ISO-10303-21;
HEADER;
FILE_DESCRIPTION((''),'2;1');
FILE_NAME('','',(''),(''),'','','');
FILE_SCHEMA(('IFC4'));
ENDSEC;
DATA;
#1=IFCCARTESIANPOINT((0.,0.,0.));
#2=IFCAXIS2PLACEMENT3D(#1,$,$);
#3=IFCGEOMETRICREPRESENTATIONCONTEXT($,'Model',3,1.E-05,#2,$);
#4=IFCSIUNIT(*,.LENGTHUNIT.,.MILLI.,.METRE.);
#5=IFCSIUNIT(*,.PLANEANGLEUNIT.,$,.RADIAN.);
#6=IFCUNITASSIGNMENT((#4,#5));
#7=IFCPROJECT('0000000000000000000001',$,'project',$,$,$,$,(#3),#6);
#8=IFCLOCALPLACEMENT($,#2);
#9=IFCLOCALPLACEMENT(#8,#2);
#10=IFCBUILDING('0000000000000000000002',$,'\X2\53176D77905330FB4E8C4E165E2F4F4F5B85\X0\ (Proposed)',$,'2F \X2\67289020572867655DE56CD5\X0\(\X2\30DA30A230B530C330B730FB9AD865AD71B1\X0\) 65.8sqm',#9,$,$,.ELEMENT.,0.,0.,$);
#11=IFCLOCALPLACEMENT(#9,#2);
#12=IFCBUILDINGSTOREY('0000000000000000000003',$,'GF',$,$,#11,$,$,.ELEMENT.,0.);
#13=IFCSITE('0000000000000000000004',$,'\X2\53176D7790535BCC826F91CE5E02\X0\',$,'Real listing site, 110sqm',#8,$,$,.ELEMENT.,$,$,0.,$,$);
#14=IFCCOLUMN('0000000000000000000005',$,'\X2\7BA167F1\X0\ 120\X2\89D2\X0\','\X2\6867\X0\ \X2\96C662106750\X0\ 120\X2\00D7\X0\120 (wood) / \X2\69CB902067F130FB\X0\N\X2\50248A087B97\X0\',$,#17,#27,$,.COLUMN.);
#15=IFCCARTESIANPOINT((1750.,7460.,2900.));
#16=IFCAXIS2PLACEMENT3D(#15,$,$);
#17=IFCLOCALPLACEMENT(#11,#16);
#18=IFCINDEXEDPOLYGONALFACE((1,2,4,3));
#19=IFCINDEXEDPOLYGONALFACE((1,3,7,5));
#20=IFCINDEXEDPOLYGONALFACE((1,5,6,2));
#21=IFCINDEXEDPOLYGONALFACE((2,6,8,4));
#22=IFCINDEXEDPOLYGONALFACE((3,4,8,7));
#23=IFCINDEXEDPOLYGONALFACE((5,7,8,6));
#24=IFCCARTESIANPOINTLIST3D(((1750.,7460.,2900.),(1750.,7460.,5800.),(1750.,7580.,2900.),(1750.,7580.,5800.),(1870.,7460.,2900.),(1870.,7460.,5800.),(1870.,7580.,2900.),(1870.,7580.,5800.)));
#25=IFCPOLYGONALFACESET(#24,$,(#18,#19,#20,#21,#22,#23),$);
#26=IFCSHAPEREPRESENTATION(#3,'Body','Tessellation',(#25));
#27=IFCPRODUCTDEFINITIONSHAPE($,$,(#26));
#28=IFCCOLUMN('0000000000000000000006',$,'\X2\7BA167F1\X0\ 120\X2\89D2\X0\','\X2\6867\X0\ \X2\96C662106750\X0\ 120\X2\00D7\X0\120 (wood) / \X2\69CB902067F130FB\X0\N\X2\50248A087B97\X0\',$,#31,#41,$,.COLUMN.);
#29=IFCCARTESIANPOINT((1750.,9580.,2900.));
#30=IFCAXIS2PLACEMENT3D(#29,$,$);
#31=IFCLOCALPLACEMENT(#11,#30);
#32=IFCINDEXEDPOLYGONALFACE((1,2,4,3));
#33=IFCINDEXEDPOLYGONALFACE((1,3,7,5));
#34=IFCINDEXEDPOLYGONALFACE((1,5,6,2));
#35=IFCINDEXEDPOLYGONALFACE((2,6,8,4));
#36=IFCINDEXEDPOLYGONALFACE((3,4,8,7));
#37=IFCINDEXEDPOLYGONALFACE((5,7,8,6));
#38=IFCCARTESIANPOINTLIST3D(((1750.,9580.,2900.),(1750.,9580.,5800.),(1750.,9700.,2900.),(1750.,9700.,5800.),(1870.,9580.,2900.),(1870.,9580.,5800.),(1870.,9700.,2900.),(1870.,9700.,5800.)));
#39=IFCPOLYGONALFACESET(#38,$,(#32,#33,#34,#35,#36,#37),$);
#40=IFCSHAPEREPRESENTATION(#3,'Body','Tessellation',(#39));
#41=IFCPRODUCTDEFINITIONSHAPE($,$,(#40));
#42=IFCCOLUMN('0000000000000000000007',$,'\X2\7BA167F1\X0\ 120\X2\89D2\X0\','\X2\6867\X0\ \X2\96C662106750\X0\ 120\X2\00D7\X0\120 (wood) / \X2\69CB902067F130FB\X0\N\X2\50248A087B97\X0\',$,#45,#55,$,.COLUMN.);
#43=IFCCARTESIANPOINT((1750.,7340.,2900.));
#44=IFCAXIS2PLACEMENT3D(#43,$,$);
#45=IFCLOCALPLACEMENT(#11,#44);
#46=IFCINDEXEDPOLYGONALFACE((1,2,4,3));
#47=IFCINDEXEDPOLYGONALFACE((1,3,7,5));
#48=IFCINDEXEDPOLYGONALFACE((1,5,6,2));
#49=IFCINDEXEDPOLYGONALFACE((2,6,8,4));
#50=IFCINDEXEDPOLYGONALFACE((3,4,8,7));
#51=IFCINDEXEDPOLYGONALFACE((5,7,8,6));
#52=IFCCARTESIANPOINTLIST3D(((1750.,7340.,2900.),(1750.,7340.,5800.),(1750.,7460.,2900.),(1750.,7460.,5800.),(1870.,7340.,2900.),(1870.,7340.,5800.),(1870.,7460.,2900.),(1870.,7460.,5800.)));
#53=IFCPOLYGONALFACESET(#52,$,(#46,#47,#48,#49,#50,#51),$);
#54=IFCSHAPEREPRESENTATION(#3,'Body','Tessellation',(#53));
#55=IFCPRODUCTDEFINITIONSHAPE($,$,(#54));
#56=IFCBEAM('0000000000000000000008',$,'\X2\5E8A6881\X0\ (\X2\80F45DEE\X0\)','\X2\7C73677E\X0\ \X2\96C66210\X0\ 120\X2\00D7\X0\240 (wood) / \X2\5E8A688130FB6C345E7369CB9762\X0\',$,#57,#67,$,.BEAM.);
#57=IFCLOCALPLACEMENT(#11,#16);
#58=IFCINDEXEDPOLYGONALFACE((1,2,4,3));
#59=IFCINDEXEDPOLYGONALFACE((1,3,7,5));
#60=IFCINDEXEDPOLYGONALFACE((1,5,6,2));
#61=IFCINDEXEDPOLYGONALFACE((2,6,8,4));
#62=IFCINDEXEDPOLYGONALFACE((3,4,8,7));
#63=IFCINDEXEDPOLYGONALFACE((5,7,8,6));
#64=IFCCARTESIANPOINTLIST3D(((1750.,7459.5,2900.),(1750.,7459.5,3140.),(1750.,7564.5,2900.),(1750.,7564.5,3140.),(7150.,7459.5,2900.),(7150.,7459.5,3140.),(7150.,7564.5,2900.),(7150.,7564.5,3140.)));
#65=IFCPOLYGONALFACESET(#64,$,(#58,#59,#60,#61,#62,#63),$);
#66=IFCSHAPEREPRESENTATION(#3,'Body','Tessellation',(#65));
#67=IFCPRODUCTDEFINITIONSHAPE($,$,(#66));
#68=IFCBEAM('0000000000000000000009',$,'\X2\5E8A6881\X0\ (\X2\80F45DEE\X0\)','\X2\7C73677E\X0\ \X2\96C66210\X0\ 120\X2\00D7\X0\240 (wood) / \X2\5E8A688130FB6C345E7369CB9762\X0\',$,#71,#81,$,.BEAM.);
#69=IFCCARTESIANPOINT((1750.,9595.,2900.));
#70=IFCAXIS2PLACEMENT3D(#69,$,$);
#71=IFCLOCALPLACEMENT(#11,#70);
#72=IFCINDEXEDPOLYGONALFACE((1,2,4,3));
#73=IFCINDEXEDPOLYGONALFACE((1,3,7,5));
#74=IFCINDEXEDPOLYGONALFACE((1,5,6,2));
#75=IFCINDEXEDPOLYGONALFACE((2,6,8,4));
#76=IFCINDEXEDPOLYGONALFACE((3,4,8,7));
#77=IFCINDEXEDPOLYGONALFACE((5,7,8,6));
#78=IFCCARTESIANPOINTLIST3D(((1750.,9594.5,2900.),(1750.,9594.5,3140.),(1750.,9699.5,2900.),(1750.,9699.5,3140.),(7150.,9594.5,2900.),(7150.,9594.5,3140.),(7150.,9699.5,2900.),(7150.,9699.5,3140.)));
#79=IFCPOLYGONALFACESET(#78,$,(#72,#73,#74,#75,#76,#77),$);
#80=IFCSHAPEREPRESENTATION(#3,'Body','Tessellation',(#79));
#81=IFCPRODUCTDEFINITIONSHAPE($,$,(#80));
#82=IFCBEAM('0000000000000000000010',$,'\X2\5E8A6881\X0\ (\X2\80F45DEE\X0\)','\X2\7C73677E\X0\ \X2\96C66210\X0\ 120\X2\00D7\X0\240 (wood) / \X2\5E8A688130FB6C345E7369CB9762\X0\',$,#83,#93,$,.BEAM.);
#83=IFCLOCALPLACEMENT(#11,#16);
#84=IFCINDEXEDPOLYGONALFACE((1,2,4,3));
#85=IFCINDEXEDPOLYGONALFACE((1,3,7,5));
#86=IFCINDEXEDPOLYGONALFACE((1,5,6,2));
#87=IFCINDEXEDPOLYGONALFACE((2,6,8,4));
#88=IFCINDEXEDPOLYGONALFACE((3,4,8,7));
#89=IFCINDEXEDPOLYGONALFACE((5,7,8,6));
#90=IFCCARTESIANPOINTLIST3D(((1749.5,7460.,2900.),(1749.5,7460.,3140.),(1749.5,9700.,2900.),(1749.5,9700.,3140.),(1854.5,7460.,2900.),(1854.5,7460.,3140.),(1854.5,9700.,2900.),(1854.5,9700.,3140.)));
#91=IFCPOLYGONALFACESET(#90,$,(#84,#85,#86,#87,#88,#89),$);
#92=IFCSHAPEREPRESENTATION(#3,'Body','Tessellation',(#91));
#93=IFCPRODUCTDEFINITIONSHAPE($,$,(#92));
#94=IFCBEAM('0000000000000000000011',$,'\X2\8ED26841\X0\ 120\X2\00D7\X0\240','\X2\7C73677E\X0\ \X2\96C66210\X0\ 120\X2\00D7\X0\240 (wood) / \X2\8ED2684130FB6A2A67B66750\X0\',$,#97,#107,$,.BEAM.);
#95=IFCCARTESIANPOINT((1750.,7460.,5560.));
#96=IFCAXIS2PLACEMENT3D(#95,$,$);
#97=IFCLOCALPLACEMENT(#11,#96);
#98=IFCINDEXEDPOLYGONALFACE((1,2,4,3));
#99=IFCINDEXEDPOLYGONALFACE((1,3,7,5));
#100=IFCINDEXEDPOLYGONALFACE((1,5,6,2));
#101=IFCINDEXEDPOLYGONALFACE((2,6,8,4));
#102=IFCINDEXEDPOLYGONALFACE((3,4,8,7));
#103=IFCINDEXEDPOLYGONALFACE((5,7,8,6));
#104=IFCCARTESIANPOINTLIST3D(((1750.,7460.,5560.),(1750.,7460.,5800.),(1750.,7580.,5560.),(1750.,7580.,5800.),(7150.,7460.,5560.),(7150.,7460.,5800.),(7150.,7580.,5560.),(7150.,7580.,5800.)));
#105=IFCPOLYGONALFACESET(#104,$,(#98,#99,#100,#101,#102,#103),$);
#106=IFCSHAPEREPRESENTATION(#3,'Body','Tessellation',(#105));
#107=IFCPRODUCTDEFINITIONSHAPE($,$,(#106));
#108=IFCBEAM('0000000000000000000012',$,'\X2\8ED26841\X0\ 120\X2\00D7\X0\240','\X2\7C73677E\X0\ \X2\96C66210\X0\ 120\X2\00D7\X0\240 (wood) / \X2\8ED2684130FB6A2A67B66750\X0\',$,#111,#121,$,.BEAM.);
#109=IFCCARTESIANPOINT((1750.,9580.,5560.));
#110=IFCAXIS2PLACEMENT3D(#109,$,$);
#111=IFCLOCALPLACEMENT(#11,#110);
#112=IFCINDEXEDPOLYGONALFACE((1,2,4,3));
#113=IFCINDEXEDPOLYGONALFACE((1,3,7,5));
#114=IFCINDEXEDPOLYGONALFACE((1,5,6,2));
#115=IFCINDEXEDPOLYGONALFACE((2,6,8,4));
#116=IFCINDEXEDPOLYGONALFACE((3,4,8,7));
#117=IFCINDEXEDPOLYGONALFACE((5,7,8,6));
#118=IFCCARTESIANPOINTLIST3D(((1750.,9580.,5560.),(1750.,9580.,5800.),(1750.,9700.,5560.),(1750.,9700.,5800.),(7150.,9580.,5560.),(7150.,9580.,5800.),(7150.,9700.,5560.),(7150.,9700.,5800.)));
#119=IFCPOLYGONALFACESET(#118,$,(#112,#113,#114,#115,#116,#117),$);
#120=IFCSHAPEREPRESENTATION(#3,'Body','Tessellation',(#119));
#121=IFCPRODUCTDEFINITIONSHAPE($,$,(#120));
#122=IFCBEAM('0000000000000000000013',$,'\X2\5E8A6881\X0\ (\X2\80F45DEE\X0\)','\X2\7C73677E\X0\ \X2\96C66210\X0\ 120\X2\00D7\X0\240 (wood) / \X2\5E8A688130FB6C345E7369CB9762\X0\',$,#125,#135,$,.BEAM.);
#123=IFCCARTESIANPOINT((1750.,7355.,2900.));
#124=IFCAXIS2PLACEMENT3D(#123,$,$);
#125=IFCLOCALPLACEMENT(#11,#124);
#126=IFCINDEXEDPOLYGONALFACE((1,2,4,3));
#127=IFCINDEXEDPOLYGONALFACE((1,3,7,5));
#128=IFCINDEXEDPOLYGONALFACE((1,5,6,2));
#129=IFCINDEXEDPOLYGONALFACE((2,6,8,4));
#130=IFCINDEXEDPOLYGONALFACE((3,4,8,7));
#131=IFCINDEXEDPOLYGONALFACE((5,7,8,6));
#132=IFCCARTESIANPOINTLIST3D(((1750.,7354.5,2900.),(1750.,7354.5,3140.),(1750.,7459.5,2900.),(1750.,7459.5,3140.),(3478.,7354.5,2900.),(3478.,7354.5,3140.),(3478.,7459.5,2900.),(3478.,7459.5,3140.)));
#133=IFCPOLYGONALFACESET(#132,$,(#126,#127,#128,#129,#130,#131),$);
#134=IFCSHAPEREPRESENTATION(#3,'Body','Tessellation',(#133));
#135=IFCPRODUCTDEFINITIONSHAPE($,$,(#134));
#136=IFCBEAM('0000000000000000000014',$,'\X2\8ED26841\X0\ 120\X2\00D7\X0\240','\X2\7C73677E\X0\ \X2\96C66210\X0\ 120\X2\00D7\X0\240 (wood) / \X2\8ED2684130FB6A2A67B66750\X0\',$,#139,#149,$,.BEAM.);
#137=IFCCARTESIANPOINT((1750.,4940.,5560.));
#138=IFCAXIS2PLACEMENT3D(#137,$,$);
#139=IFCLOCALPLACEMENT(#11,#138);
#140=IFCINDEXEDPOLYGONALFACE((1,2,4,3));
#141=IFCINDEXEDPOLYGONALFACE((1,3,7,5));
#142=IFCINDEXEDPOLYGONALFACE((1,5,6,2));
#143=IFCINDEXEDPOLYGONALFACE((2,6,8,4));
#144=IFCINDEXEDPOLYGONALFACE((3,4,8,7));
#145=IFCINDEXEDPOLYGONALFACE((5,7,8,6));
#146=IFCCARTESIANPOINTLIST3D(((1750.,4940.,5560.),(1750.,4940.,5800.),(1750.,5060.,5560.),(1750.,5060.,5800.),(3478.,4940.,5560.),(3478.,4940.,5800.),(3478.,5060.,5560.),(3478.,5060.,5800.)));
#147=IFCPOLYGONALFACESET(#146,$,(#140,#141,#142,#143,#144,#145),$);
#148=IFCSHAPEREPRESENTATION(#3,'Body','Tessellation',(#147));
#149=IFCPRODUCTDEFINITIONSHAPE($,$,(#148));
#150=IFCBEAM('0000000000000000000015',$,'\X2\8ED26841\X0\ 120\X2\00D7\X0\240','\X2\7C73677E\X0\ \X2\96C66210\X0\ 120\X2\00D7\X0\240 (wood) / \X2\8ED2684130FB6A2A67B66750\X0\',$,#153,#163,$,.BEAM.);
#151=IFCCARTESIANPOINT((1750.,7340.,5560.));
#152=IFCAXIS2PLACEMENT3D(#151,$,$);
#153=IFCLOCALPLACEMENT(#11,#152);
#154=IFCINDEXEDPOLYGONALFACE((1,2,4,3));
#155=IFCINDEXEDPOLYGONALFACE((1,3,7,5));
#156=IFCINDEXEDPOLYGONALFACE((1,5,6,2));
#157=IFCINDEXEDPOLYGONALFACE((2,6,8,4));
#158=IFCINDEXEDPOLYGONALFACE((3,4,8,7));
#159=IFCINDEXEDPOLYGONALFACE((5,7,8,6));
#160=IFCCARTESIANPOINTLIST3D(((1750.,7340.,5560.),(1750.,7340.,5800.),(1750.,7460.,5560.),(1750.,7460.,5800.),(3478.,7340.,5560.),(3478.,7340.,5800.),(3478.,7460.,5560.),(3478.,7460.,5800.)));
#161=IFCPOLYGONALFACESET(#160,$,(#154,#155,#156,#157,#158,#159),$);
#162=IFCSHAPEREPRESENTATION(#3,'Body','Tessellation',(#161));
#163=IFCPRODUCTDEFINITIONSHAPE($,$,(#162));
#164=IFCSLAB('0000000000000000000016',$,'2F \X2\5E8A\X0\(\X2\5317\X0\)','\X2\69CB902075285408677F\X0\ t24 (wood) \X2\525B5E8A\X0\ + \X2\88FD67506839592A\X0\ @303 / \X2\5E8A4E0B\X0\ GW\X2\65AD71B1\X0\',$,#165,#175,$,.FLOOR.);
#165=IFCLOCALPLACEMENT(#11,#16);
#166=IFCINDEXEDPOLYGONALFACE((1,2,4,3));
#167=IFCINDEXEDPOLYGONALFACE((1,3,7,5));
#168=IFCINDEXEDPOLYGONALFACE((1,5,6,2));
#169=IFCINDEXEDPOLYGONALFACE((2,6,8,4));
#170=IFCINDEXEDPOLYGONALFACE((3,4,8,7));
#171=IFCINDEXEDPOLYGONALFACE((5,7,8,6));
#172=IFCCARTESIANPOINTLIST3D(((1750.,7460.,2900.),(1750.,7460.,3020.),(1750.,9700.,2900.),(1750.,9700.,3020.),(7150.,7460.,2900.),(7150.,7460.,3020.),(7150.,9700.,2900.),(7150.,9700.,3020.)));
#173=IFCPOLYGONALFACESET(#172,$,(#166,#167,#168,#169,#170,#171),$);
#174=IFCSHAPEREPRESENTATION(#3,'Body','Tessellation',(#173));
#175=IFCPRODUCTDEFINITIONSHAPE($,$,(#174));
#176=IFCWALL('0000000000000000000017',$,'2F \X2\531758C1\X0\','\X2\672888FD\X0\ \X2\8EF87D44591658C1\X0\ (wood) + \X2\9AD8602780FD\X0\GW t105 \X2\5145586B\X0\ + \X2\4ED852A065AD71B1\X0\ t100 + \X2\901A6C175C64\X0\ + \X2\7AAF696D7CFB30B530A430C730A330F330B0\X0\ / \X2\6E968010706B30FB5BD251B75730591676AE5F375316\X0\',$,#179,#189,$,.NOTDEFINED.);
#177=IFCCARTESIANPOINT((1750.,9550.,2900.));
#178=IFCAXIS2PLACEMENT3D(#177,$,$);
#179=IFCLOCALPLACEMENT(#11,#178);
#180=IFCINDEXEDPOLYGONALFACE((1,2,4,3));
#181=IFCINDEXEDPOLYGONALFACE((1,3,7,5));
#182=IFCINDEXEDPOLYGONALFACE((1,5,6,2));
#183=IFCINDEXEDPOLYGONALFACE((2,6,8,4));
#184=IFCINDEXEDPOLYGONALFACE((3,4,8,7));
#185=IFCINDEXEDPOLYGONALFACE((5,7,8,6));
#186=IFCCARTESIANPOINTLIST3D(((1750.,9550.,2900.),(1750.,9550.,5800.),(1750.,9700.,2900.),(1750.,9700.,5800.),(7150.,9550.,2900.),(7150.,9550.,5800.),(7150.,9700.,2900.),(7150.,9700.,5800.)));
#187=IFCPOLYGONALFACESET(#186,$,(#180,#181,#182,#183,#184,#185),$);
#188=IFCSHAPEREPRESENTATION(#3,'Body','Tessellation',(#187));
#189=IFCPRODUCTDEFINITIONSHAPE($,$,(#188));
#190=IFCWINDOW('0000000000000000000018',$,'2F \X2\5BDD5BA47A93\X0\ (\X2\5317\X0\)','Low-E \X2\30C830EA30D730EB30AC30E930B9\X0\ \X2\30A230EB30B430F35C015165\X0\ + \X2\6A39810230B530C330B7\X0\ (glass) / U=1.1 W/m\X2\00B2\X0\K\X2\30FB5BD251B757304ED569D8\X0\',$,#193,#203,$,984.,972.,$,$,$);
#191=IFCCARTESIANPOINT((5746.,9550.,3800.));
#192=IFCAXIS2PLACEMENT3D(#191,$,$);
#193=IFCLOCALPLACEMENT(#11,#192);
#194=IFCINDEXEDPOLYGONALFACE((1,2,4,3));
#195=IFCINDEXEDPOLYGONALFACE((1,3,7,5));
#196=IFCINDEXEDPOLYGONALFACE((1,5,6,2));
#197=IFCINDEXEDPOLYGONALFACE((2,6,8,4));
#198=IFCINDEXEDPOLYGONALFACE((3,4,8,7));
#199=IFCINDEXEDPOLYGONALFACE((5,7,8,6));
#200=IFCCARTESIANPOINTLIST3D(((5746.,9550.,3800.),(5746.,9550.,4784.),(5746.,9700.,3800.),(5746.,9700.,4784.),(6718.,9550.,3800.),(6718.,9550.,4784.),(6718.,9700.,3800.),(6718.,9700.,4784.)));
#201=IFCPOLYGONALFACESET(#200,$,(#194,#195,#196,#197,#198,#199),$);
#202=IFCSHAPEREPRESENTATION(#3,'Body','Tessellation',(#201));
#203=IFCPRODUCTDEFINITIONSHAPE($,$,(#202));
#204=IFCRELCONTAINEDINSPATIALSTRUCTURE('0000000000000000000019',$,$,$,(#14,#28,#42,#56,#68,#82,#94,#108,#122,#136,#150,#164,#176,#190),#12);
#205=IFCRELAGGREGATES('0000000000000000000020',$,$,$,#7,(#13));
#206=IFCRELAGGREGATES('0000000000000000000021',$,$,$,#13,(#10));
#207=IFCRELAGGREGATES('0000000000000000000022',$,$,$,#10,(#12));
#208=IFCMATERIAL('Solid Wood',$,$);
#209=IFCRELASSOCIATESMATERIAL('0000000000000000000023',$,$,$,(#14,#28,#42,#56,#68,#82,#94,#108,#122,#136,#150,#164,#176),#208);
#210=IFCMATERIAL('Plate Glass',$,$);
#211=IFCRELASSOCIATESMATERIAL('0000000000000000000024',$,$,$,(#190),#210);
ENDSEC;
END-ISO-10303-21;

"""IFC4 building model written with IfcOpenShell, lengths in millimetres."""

from ifc_helpers import new_model, si_unit, frame, frame_2d, origin, place, context, project, spatial, rectangle, extrude, material, element, fill, save


model = new_model("IFC4")

# Units and contexts
model_context = context("Model", 3, precision=1e-05, world=origin())
ifc_project = project(units=[si_unit("LENGTHUNIT", "METRE", prefix="MILLI"), si_unit("PLANEANGLEUNIT", "RADIAN")], contexts=[model_context])

# Site, building, storey
site_placement = place(None, origin())
site = spatial("IfcSite", under=ifc_project, at=site_placement, Name="北海道富良野市", ObjectType="Real listing site, 110sqm", CompositionType="ELEMENT", RefElevation=0.0)
building_placement = place(site_placement, origin())
building = spatial("IfcBuilding", under=site, at=building_placement, Name="北海道・二世帯住宅 (Proposed)", ObjectType="2F 木造在来工法(ペアサッシ・高断熱) 65.8sqm", CompositionType="ELEMENT", ElevationOfRefHeight=0.0, ElevationOfTerrain=0.0)
storey_placement = place(building_placement, origin())
storey = spatial("IfcBuildingStorey", under=building, at=storey_placement, Name="GF", CompositionType="ELEMENT", Elevation=0.0)

# Columns
ifc_material_1 = material(Name="Solid Wood")
column_1_placement = place(storey_placement, frame((1750.0, 7460.0, 2900.0)))
element("IfcColumn", 1, at=column_1_placement, inside=storey, material=ifc_material_1, Name="管柱 120角", Description="桧 集成材 120×120 (wood) / 構造柱・N値計算", PredefinedType="COLUMN", context=model_context, shape_type="SweptSolid", body=[
    extrude(rectangle(XDim=120.0, YDim=120.0, at=frame_2d((60.0, 60.0))), frame((1750.0, 7460.0, 2900.0)), (0.0, 0.0, 1.0), 2900.0),
])
column_2_placement = place(storey_placement, frame((1750.0, 9580.0, 2900.0)))
element("IfcColumn", 2, at=column_2_placement, inside=storey, material=ifc_material_1, Name="管柱 120角", Description="桧 集成材 120×120 (wood) / 構造柱・N値計算", PredefinedType="COLUMN", context=model_context, shape_type="SweptSolid", body=[
    extrude(rectangle(XDim=120.0, YDim=120.0, at=frame_2d((60.0, 60.0))), frame((1750.0, 9580.0, 2900.0)), (0.0, 0.0, 1.0), 2900.0),
])
column_3_placement = place(storey_placement, frame((1750.0, 7340.0, 2900.0)))
element("IfcColumn", 3, at=column_3_placement, inside=storey, material=ifc_material_1, Name="管柱 120角", Description="桧 集成材 120×120 (wood) / 構造柱・N値計算", PredefinedType="COLUMN", context=model_context, shape_type="SweptSolid", body=[
    extrude(rectangle(XDim=120.0, YDim=120.0, at=frame_2d((60.0, 60.0))), frame((1750.0, 7340.0, 2900.0)), (0.0, 0.0, 1.0), 2900.0),
])

# Beams
beam_1_placement = place(storey_placement, frame((1750.0, 7460.0, 2900.0)))
element("IfcBeam", 4, at=beam_1_placement, inside=storey, material=ifc_material_1, Name="床梁 (胴差)", Description="米松 集成 120×240 (wood) / 床梁・水平構面", PredefinedType="BEAM", context=model_context, shape_type="SweptSolid", body=[
    extrude(rectangle(XDim=5400.0, YDim=105.0, at=frame_2d((2700.0, 52.0))), frame((1750.0, 7460.0, 2900.0)), (0.0, 0.0, 1.0), 240.0),
])
beam_2_placement = place(storey_placement, frame((1750.0, 9595.0, 2900.0)))
element("IfcBeam", 5, at=beam_2_placement, inside=storey, material=ifc_material_1, Name="床梁 (胴差)", Description="米松 集成 120×240 (wood) / 床梁・水平構面", PredefinedType="BEAM", context=model_context, shape_type="SweptSolid", body=[
    extrude(rectangle(XDim=5400.0, YDim=105.0, at=frame_2d((2700.0, 52.0))), frame((1750.0, 9595.0, 2900.0)), (0.0, 0.0, 1.0), 240.0),
])
beam_3_placement = place(storey_placement, frame((1750.0, 7460.0, 2900.0)))
element("IfcBeam", 6, at=beam_3_placement, inside=storey, material=ifc_material_1, Name="床梁 (胴差)", Description="米松 集成 120×240 (wood) / 床梁・水平構面", PredefinedType="BEAM", context=model_context, shape_type="SweptSolid", body=[
    extrude(rectangle(XDim=105.0, YDim=2240.0, at=frame_2d((52.0, 1120.0))), frame((1750.0, 7460.0, 2900.0)), (0.0, 0.0, 1.0), 240.0),
])
beam_4_placement = place(storey_placement, frame((1750.0, 7460.0, 5560.0)))
element("IfcBeam", 7, at=beam_4_placement, inside=storey, material=ifc_material_1, Name="軒桁 120×240", Description="米松 集成 120×240 (wood) / 軒桁・横架材", PredefinedType="BEAM", context=model_context, shape_type="SweptSolid", body=[
    extrude(rectangle(XDim=5400.0, YDim=120.0, at=frame_2d((2700.0, 60.0))), frame((1750.0, 7460.0, 5560.0)), (0.0, 0.0, 1.0), 240.0),
])
beam_5_placement = place(storey_placement, frame((1750.0, 9580.0, 5560.0)))
element("IfcBeam", 8, at=beam_5_placement, inside=storey, material=ifc_material_1, Name="軒桁 120×240", Description="米松 集成 120×240 (wood) / 軒桁・横架材", PredefinedType="BEAM", context=model_context, shape_type="SweptSolid", body=[
    extrude(rectangle(XDim=5400.0, YDim=120.0, at=frame_2d((2700.0, 60.0))), frame((1750.0, 9580.0, 5560.0)), (0.0, 0.0, 1.0), 240.0),
])
beam_6_placement = place(storey_placement, frame((1750.0, 7355.0, 2900.0)))
element("IfcBeam", 9, at=beam_6_placement, inside=storey, material=ifc_material_1, Name="床梁 (胴差)", Description="米松 集成 120×240 (wood) / 床梁・水平構面", PredefinedType="BEAM", context=model_context, shape_type="SweptSolid", body=[
    extrude(rectangle(XDim=1728.0, YDim=105.0, at=frame_2d((864.0, 52.0))), frame((1750.0, 7355.0, 2900.0)), (0.0, 0.0, 1.0), 240.0),
])
beam_7_placement = place(storey_placement, frame((1750.0, 4940.0, 5560.0)))
element("IfcBeam", 10, at=beam_7_placement, inside=storey, material=ifc_material_1, Name="軒桁 120×240", Description="米松 集成 120×240 (wood) / 軒桁・横架材", PredefinedType="BEAM", context=model_context, shape_type="SweptSolid", body=[
    extrude(rectangle(XDim=1728.0, YDim=120.0, at=frame_2d((864.0, 60.0))), frame((1750.0, 4940.0, 5560.0)), (0.0, 0.0, 1.0), 240.0),
])
beam_8_placement = place(storey_placement, frame((1750.0, 7340.0, 5560.0)))
element("IfcBeam", 11, at=beam_8_placement, inside=storey, material=ifc_material_1, Name="軒桁 120×240", Description="米松 集成 120×240 (wood) / 軒桁・横架材", PredefinedType="BEAM", context=model_context, shape_type="SweptSolid", body=[
    extrude(rectangle(XDim=1728.0, YDim=120.0, at=frame_2d((864.0, 60.0))), frame((1750.0, 7340.0, 5560.0)), (0.0, 0.0, 1.0), 240.0),
])

# Slab
slab_placement = place(storey_placement, frame((1750.0, 7460.0, 2900.0)))
element("IfcSlab", 12, at=slab_placement, inside=storey, material=ifc_material_1, Name="2F 床(北)", Description="構造用合板 t24 (wood) 剛床 + 製材根太 @303 / 床下 GW断熱", PredefinedType="FLOOR", context=model_context, shape_type="SweptSolid", body=[
    extrude(rectangle(XDim=5400.0, YDim=2240.0, at=frame_2d((2700.0, 1120.0))), frame((1750.0, 7460.0, 2900.0)), (0.0, 0.0, 1.0), 120.0),
])

# Wall, opening, window
wall_placement = place(storey_placement, frame((1750.0, 9550.0, 2900.0)))
wall = element("IfcWall", 13, at=wall_placement, inside=storey, material=ifc_material_1, Name="2F 北壁", Description="木製 軸組外壁 (wood) + 高性能GW t105 充填 + 付加断熱 t100 + 通気層 + 窯業系サイディング / 準耐火・寒冷地外皮強化", PredefinedType="NOTDEFINED", context=model_context, shape_type="SweptSolid", body=[
    extrude(rectangle(XDim=5400.0, YDim=150.0, at=frame_2d((2700.0, 75.0))), frame((1750.0, 9550.0, 2900.0)), (0.0, 0.0, 1.0), 2900.0),
])
opening_placement = place(storey_placement, frame((5746.0, 9550.0, 3800.0)))
opening = element("IfcOpeningElement", 14, at=opening_placement, cuts=wall, PredefinedType="NOTDEFINED", context=model_context, shape_type="SweptSolid", body=[
    extrude(rectangle(XDim=972.0, YDim=150.0, at=frame_2d((486.0, 75.0))), frame((5746.0, 9550.0, 3800.0)), (0.0, 0.0, 1.0), 984.0),
])
ifc_material_2 = material(Name="Plate Glass")
window_placement = place(storey_placement, frame((5746.0, 9550.0, 3800.0)))
window = element("IfcWindow", 15, at=window_placement, inside=storey, material=ifc_material_2, Name="2F 寝室窓 (北)", Description="Low-E トリプルガラス アルゴン封入 + 樹脂サッシ (glass) / U=1.1 W/m²K・寒冷地仕様", OverallHeight=984.0, OverallWidth=972.0, context=model_context, shape_type="SweptSolid", body=[
    extrude(rectangle(XDim=972.0, YDim=150.0, at=frame_2d((486.0, 75.0))), frame((5746.0, 9550.0, 3800.0)), (0.0, 0.0, 1.0), 984.0),
])
fill(opening, window)

save(model, "model.ifc")
